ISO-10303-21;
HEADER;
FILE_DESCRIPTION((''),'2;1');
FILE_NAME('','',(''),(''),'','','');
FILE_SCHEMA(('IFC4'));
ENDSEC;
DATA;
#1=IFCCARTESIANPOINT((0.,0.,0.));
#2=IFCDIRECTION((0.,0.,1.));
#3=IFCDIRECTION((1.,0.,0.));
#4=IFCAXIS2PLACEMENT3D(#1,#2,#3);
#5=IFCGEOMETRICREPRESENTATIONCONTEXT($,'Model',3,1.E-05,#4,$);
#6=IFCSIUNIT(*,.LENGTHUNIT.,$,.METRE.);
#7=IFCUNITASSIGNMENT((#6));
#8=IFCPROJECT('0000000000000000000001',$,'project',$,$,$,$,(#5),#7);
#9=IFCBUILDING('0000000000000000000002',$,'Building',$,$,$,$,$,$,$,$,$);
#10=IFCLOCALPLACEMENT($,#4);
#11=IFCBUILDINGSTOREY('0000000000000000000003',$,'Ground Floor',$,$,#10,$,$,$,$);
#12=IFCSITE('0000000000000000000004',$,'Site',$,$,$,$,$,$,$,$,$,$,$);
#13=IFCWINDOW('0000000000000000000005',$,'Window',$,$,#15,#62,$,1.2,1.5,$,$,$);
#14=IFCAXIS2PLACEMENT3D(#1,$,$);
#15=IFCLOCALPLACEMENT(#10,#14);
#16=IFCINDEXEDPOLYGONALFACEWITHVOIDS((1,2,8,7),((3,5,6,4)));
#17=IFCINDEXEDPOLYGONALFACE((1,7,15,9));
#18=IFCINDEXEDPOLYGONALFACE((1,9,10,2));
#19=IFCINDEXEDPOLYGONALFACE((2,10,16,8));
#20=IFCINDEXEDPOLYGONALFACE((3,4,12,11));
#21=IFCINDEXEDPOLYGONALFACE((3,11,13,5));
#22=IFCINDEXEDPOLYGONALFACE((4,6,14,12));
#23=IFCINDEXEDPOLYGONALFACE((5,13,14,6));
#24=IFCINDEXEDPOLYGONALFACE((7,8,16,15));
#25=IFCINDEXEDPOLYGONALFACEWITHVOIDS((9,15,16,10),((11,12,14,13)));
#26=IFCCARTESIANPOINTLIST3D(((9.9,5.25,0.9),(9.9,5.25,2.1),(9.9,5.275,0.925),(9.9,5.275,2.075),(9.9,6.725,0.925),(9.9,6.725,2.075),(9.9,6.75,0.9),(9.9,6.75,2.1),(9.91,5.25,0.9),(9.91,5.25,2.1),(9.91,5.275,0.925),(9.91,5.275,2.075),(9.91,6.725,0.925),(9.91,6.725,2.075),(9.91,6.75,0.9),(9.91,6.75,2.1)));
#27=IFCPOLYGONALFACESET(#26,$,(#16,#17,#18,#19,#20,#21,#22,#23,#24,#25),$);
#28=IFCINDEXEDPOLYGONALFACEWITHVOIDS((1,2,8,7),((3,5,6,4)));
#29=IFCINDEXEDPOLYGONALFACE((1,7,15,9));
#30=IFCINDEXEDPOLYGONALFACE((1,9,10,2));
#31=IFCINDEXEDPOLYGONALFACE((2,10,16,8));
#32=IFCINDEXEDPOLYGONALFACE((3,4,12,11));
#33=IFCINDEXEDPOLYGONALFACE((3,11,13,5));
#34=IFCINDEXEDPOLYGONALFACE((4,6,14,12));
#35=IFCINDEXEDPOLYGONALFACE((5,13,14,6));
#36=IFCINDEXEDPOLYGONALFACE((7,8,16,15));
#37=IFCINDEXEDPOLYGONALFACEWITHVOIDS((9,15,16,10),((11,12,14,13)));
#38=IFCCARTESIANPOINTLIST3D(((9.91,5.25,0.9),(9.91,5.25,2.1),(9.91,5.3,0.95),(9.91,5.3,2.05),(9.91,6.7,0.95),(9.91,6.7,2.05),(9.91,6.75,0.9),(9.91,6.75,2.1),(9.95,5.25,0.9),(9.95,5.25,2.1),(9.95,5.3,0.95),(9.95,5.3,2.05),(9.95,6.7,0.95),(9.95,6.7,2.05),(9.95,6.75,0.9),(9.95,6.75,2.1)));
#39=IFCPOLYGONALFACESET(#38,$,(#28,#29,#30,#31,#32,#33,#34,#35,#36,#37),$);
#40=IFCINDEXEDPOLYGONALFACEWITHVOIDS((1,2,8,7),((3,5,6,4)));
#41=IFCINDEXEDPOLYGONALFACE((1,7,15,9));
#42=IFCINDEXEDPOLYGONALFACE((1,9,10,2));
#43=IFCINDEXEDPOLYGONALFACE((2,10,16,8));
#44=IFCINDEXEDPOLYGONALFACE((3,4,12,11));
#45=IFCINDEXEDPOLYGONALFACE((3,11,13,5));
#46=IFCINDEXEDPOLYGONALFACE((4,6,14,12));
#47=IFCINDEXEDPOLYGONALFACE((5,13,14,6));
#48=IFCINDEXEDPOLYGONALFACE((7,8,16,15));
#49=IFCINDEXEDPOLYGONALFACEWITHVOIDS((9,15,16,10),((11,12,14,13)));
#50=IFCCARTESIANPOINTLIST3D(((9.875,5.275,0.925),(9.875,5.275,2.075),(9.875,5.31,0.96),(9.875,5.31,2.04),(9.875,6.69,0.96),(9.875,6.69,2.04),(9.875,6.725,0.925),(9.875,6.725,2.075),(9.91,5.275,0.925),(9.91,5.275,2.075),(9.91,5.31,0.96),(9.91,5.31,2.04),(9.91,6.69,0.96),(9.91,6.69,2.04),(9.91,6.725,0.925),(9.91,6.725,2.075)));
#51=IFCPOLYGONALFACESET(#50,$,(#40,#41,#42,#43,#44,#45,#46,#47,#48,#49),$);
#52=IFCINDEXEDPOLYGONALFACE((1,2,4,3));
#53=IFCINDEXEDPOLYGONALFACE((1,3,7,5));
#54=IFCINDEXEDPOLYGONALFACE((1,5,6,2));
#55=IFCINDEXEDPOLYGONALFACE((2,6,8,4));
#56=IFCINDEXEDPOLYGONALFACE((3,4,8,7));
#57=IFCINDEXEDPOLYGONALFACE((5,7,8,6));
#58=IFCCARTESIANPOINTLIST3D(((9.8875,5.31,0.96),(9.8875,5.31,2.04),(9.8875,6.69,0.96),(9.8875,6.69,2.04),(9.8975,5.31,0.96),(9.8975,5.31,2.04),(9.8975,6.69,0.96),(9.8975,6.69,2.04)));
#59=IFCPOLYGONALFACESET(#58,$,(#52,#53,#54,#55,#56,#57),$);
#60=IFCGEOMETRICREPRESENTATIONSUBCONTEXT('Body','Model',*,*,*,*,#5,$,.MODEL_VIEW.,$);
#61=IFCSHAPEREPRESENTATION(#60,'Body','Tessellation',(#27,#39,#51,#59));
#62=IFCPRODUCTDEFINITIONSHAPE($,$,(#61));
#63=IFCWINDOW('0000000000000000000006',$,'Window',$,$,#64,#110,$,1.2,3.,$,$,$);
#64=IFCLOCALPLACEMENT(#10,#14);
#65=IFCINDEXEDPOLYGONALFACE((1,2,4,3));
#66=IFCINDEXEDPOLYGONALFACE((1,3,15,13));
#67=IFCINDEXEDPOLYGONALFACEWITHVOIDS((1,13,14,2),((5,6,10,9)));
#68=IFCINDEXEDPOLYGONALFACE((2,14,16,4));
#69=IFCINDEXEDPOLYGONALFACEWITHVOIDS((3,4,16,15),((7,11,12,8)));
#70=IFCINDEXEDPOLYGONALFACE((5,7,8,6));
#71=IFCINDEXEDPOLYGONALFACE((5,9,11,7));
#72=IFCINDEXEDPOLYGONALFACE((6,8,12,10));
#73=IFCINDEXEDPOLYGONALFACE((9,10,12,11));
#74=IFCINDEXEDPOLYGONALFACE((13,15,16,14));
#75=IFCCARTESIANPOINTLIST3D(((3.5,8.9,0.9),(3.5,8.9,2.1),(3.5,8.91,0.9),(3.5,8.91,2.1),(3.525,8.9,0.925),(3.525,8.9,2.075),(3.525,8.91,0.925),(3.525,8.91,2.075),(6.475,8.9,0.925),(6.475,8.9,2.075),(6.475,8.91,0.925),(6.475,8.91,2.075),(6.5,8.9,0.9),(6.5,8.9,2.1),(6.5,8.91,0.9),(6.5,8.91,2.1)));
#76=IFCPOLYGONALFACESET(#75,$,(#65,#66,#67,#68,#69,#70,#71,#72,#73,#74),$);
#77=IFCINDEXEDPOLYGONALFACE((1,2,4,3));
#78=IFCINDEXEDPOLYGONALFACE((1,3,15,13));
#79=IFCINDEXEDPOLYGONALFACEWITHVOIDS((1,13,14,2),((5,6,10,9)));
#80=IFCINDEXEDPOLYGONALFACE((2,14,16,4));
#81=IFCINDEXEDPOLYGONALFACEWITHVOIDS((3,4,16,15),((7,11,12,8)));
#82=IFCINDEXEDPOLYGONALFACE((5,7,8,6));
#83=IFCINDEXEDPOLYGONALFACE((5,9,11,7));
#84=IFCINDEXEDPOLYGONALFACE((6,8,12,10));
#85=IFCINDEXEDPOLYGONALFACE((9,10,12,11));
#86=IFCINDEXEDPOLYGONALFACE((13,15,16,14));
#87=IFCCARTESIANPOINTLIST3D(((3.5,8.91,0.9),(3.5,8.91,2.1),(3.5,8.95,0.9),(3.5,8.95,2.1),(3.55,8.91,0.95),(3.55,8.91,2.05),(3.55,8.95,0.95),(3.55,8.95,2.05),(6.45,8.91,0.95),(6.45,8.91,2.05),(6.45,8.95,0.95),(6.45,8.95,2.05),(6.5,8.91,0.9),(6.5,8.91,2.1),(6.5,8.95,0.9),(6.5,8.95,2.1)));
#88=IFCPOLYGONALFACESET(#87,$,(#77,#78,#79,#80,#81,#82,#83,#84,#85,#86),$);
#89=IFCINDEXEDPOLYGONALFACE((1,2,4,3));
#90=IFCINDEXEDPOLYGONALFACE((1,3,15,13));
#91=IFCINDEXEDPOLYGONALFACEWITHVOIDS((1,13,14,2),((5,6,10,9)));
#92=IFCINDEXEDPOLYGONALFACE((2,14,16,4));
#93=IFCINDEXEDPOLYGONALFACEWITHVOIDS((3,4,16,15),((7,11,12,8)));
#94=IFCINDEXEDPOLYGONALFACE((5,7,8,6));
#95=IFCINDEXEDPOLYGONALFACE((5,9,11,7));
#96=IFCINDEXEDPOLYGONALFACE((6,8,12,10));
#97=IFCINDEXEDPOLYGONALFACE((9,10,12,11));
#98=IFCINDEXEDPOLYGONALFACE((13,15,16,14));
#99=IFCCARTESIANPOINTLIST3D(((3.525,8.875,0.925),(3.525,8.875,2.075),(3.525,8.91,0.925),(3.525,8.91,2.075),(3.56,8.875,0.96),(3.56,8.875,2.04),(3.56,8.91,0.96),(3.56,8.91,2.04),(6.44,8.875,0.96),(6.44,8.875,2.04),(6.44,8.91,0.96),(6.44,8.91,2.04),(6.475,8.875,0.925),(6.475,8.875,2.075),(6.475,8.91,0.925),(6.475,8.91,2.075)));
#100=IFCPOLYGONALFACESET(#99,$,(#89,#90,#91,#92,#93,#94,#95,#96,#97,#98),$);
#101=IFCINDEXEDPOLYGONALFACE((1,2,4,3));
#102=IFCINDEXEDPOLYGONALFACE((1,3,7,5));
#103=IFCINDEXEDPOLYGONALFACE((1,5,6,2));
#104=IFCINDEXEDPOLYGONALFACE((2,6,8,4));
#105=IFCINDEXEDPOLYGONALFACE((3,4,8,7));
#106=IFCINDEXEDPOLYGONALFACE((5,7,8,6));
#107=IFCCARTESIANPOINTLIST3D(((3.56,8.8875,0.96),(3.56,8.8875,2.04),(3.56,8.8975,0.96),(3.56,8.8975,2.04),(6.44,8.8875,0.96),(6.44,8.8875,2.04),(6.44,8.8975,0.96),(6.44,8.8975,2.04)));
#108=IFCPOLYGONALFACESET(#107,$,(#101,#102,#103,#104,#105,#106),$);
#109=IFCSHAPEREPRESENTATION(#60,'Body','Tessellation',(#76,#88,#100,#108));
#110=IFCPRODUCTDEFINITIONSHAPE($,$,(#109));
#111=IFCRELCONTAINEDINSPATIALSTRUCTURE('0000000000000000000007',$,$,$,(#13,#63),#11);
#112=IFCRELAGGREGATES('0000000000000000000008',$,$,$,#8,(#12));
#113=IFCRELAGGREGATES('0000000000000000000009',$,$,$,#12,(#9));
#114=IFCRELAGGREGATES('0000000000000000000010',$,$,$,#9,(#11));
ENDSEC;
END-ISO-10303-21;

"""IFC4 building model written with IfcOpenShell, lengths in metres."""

from ifc_helpers import new_model, si_unit, frame, origin_with_axes, place, context, subcontext, project, spatial, line, indexed_curve, outline, extrude, element, save


model = new_model("IFC4")

# Units and contexts
model_context = context("Model", 3, precision=1e-05, world=origin_with_axes())
body_context = subcontext(model_context, "Body", "Model", "MODEL_VIEW")
ifc_project = project(units=[si_unit("LENGTHUNIT", "METRE")], contexts=[model_context])

# Site, building, storey
site = spatial("IfcSite", under=ifc_project, Name="Site")
building = spatial("IfcBuilding", under=site, Name="Building")
storey_placement = place(None, origin_with_axes())
storey = spatial("IfcBuildingStorey", under=building, at=storey_placement, Name="Ground Floor")

# Windows
for number, where, z_axis, x_axis, name in (
    (1, (10.0, 5.25, 0.9), (0.0, 0.0, 1.0), (0.0, 1.0, 0.0), "Window"),
):
    element("IfcWindow", number, at=place(storey_placement, frame(where, z_axis=z_axis, x_axis=x_axis)), inside=storey, Name=name, OverallHeight=1.2, OverallWidth=1.5, context=body_context, shape_type="SweptSolid", body=[
        extrude(outline(indexed_curve([(0.0, 0.0), (1.5, 0.0), (1.5, 1.2), (0.0, 1.2)], segments=[line(1, 2, 3, 4, 1)]), holes=[indexed_curve([(0.025, 0.025), (1.475, 0.025), (1.475, 1.175), (0.025, 1.175)], segments=[line(1, 2, 3, 4, 1)])]), frame((0.0, 0.09, 0.0), z_axis=(0.0, -1.0, 0.0), x_axis=(1.0, 0.0, 0.0)), (0.0, 0.0, -1.0), 0.01),
        extrude(outline(indexed_curve([(0.0, 0.0), (1.5, 0.0), (1.5, 1.2), (0.0, 1.2)], segments=[line(1, 2, 3, 4, 1)]), holes=[indexed_curve([(0.05, 0.05), (1.45, 0.05), (1.45, 1.15), (0.05, 1.15)], segments=[line(1, 2, 3, 4, 1)])]), frame((0.0, 0.05, 0.0), z_axis=(0.0, -1.0, 0.0), x_axis=(1.0, 0.0, 0.0)), (0.0, 0.0, -1.0), 0.04),
        extrude(outline(indexed_curve([(0.0, 0.0), (1.45, 0.0), (1.45, 1.15), (0.0, 1.15)], segments=[line(1, 2, 3, 4, 1)]), holes=[indexed_curve([(0.035, 0.035), (1.415, 0.035), (1.415, 1.115), (0.035, 1.115)], segments=[line(1, 2, 3, 4, 1)])]), frame((0.025, 0.09, 0.025), z_axis=(0.0, -1.0, 0.0), x_axis=(1.0, 0.0, 0.0)), (0.0, 0.0, -1.0), 0.035),
        extrude(outline(indexed_curve([(0.035, 0.035), (1.415, 0.035), (1.415, 1.115), (0.035, 1.115)], segments=[line(1, 2, 3, 4, 1)])), frame((0.025, 0.1025, 0.025), z_axis=(0.0, -1.0, 0.0), x_axis=(1.0, 0.0, 0.0)), (0.0, 0.0, -1.0), 0.01),
    ])
window_1_placement = place(storey_placement, frame((6.5, 9.0, 0.9), z_axis=(0.0, 0.0, 1.0), x_axis=(-1.0, 0.0, 0.0)))
element("IfcWindow", 2, at=window_1_placement, inside=storey, Name="Window", OverallHeight=1.2, OverallWidth=3.0, context=body_context, shape_type="SweptSolid", body=[
    extrude(outline(indexed_curve([(0.0, 0.0), (3.0, 0.0), (3.0, 1.2), (0.0, 1.2)], segments=[line(1, 2, 3, 4, 1)]), holes=[indexed_curve([(0.025, 0.025), (2.975, 0.025), (2.975, 1.175), (0.025, 1.175)], segments=[line(1, 2, 3, 4, 1)])]), frame((0.0, 0.09, 0.0), z_axis=(0.0, -1.0, 0.0), x_axis=(1.0, 0.0, 0.0)), (0.0, 0.0, -1.0), 0.01),
    extrude(outline(indexed_curve([(0.0, 0.0), (3.0, 0.0), (3.0, 1.2), (0.0, 1.2)], segments=[line(1, 2, 3, 4, 1)]), holes=[indexed_curve([(0.05, 0.05), (2.95, 0.05), (2.95, 1.15), (0.05, 1.15)], segments=[line(1, 2, 3, 4, 1)])]), frame((0.0, 0.05, 0.0), z_axis=(0.0, -1.0, 0.0), x_axis=(1.0, 0.0, 0.0)), (0.0, 0.0, -1.0), 0.04),
    extrude(outline(indexed_curve([(0.0, 0.0), (2.95, 0.0), (2.95, 1.15), (0.0, 1.15)], segments=[line(1, 2, 3, 4, 1)]), holes=[indexed_curve([(0.035, 0.035), (2.915, 0.035), (2.915, 1.115), (0.035, 1.115)], segments=[line(1, 2, 3, 4, 1)])]), frame((0.025, 0.09, 0.025), z_axis=(0.0, -1.0, 0.0), x_axis=(1.0, 0.0, 0.0)), (0.0, 0.0, -1.0), 0.035),
    extrude(outline(indexed_curve([(0.035, 0.035), (2.915, 0.035), (2.915, 1.115), (0.035, 1.115)], segments=[line(1, 2, 3, 4, 1)])), frame((0.025, 0.1025, 0.025), z_axis=(0.0, -1.0, 0.0), x_axis=(1.0, 0.0, 0.0)), (0.0, 0.0, -1.0), 0.01),
])

save(model, "model.ifc")
